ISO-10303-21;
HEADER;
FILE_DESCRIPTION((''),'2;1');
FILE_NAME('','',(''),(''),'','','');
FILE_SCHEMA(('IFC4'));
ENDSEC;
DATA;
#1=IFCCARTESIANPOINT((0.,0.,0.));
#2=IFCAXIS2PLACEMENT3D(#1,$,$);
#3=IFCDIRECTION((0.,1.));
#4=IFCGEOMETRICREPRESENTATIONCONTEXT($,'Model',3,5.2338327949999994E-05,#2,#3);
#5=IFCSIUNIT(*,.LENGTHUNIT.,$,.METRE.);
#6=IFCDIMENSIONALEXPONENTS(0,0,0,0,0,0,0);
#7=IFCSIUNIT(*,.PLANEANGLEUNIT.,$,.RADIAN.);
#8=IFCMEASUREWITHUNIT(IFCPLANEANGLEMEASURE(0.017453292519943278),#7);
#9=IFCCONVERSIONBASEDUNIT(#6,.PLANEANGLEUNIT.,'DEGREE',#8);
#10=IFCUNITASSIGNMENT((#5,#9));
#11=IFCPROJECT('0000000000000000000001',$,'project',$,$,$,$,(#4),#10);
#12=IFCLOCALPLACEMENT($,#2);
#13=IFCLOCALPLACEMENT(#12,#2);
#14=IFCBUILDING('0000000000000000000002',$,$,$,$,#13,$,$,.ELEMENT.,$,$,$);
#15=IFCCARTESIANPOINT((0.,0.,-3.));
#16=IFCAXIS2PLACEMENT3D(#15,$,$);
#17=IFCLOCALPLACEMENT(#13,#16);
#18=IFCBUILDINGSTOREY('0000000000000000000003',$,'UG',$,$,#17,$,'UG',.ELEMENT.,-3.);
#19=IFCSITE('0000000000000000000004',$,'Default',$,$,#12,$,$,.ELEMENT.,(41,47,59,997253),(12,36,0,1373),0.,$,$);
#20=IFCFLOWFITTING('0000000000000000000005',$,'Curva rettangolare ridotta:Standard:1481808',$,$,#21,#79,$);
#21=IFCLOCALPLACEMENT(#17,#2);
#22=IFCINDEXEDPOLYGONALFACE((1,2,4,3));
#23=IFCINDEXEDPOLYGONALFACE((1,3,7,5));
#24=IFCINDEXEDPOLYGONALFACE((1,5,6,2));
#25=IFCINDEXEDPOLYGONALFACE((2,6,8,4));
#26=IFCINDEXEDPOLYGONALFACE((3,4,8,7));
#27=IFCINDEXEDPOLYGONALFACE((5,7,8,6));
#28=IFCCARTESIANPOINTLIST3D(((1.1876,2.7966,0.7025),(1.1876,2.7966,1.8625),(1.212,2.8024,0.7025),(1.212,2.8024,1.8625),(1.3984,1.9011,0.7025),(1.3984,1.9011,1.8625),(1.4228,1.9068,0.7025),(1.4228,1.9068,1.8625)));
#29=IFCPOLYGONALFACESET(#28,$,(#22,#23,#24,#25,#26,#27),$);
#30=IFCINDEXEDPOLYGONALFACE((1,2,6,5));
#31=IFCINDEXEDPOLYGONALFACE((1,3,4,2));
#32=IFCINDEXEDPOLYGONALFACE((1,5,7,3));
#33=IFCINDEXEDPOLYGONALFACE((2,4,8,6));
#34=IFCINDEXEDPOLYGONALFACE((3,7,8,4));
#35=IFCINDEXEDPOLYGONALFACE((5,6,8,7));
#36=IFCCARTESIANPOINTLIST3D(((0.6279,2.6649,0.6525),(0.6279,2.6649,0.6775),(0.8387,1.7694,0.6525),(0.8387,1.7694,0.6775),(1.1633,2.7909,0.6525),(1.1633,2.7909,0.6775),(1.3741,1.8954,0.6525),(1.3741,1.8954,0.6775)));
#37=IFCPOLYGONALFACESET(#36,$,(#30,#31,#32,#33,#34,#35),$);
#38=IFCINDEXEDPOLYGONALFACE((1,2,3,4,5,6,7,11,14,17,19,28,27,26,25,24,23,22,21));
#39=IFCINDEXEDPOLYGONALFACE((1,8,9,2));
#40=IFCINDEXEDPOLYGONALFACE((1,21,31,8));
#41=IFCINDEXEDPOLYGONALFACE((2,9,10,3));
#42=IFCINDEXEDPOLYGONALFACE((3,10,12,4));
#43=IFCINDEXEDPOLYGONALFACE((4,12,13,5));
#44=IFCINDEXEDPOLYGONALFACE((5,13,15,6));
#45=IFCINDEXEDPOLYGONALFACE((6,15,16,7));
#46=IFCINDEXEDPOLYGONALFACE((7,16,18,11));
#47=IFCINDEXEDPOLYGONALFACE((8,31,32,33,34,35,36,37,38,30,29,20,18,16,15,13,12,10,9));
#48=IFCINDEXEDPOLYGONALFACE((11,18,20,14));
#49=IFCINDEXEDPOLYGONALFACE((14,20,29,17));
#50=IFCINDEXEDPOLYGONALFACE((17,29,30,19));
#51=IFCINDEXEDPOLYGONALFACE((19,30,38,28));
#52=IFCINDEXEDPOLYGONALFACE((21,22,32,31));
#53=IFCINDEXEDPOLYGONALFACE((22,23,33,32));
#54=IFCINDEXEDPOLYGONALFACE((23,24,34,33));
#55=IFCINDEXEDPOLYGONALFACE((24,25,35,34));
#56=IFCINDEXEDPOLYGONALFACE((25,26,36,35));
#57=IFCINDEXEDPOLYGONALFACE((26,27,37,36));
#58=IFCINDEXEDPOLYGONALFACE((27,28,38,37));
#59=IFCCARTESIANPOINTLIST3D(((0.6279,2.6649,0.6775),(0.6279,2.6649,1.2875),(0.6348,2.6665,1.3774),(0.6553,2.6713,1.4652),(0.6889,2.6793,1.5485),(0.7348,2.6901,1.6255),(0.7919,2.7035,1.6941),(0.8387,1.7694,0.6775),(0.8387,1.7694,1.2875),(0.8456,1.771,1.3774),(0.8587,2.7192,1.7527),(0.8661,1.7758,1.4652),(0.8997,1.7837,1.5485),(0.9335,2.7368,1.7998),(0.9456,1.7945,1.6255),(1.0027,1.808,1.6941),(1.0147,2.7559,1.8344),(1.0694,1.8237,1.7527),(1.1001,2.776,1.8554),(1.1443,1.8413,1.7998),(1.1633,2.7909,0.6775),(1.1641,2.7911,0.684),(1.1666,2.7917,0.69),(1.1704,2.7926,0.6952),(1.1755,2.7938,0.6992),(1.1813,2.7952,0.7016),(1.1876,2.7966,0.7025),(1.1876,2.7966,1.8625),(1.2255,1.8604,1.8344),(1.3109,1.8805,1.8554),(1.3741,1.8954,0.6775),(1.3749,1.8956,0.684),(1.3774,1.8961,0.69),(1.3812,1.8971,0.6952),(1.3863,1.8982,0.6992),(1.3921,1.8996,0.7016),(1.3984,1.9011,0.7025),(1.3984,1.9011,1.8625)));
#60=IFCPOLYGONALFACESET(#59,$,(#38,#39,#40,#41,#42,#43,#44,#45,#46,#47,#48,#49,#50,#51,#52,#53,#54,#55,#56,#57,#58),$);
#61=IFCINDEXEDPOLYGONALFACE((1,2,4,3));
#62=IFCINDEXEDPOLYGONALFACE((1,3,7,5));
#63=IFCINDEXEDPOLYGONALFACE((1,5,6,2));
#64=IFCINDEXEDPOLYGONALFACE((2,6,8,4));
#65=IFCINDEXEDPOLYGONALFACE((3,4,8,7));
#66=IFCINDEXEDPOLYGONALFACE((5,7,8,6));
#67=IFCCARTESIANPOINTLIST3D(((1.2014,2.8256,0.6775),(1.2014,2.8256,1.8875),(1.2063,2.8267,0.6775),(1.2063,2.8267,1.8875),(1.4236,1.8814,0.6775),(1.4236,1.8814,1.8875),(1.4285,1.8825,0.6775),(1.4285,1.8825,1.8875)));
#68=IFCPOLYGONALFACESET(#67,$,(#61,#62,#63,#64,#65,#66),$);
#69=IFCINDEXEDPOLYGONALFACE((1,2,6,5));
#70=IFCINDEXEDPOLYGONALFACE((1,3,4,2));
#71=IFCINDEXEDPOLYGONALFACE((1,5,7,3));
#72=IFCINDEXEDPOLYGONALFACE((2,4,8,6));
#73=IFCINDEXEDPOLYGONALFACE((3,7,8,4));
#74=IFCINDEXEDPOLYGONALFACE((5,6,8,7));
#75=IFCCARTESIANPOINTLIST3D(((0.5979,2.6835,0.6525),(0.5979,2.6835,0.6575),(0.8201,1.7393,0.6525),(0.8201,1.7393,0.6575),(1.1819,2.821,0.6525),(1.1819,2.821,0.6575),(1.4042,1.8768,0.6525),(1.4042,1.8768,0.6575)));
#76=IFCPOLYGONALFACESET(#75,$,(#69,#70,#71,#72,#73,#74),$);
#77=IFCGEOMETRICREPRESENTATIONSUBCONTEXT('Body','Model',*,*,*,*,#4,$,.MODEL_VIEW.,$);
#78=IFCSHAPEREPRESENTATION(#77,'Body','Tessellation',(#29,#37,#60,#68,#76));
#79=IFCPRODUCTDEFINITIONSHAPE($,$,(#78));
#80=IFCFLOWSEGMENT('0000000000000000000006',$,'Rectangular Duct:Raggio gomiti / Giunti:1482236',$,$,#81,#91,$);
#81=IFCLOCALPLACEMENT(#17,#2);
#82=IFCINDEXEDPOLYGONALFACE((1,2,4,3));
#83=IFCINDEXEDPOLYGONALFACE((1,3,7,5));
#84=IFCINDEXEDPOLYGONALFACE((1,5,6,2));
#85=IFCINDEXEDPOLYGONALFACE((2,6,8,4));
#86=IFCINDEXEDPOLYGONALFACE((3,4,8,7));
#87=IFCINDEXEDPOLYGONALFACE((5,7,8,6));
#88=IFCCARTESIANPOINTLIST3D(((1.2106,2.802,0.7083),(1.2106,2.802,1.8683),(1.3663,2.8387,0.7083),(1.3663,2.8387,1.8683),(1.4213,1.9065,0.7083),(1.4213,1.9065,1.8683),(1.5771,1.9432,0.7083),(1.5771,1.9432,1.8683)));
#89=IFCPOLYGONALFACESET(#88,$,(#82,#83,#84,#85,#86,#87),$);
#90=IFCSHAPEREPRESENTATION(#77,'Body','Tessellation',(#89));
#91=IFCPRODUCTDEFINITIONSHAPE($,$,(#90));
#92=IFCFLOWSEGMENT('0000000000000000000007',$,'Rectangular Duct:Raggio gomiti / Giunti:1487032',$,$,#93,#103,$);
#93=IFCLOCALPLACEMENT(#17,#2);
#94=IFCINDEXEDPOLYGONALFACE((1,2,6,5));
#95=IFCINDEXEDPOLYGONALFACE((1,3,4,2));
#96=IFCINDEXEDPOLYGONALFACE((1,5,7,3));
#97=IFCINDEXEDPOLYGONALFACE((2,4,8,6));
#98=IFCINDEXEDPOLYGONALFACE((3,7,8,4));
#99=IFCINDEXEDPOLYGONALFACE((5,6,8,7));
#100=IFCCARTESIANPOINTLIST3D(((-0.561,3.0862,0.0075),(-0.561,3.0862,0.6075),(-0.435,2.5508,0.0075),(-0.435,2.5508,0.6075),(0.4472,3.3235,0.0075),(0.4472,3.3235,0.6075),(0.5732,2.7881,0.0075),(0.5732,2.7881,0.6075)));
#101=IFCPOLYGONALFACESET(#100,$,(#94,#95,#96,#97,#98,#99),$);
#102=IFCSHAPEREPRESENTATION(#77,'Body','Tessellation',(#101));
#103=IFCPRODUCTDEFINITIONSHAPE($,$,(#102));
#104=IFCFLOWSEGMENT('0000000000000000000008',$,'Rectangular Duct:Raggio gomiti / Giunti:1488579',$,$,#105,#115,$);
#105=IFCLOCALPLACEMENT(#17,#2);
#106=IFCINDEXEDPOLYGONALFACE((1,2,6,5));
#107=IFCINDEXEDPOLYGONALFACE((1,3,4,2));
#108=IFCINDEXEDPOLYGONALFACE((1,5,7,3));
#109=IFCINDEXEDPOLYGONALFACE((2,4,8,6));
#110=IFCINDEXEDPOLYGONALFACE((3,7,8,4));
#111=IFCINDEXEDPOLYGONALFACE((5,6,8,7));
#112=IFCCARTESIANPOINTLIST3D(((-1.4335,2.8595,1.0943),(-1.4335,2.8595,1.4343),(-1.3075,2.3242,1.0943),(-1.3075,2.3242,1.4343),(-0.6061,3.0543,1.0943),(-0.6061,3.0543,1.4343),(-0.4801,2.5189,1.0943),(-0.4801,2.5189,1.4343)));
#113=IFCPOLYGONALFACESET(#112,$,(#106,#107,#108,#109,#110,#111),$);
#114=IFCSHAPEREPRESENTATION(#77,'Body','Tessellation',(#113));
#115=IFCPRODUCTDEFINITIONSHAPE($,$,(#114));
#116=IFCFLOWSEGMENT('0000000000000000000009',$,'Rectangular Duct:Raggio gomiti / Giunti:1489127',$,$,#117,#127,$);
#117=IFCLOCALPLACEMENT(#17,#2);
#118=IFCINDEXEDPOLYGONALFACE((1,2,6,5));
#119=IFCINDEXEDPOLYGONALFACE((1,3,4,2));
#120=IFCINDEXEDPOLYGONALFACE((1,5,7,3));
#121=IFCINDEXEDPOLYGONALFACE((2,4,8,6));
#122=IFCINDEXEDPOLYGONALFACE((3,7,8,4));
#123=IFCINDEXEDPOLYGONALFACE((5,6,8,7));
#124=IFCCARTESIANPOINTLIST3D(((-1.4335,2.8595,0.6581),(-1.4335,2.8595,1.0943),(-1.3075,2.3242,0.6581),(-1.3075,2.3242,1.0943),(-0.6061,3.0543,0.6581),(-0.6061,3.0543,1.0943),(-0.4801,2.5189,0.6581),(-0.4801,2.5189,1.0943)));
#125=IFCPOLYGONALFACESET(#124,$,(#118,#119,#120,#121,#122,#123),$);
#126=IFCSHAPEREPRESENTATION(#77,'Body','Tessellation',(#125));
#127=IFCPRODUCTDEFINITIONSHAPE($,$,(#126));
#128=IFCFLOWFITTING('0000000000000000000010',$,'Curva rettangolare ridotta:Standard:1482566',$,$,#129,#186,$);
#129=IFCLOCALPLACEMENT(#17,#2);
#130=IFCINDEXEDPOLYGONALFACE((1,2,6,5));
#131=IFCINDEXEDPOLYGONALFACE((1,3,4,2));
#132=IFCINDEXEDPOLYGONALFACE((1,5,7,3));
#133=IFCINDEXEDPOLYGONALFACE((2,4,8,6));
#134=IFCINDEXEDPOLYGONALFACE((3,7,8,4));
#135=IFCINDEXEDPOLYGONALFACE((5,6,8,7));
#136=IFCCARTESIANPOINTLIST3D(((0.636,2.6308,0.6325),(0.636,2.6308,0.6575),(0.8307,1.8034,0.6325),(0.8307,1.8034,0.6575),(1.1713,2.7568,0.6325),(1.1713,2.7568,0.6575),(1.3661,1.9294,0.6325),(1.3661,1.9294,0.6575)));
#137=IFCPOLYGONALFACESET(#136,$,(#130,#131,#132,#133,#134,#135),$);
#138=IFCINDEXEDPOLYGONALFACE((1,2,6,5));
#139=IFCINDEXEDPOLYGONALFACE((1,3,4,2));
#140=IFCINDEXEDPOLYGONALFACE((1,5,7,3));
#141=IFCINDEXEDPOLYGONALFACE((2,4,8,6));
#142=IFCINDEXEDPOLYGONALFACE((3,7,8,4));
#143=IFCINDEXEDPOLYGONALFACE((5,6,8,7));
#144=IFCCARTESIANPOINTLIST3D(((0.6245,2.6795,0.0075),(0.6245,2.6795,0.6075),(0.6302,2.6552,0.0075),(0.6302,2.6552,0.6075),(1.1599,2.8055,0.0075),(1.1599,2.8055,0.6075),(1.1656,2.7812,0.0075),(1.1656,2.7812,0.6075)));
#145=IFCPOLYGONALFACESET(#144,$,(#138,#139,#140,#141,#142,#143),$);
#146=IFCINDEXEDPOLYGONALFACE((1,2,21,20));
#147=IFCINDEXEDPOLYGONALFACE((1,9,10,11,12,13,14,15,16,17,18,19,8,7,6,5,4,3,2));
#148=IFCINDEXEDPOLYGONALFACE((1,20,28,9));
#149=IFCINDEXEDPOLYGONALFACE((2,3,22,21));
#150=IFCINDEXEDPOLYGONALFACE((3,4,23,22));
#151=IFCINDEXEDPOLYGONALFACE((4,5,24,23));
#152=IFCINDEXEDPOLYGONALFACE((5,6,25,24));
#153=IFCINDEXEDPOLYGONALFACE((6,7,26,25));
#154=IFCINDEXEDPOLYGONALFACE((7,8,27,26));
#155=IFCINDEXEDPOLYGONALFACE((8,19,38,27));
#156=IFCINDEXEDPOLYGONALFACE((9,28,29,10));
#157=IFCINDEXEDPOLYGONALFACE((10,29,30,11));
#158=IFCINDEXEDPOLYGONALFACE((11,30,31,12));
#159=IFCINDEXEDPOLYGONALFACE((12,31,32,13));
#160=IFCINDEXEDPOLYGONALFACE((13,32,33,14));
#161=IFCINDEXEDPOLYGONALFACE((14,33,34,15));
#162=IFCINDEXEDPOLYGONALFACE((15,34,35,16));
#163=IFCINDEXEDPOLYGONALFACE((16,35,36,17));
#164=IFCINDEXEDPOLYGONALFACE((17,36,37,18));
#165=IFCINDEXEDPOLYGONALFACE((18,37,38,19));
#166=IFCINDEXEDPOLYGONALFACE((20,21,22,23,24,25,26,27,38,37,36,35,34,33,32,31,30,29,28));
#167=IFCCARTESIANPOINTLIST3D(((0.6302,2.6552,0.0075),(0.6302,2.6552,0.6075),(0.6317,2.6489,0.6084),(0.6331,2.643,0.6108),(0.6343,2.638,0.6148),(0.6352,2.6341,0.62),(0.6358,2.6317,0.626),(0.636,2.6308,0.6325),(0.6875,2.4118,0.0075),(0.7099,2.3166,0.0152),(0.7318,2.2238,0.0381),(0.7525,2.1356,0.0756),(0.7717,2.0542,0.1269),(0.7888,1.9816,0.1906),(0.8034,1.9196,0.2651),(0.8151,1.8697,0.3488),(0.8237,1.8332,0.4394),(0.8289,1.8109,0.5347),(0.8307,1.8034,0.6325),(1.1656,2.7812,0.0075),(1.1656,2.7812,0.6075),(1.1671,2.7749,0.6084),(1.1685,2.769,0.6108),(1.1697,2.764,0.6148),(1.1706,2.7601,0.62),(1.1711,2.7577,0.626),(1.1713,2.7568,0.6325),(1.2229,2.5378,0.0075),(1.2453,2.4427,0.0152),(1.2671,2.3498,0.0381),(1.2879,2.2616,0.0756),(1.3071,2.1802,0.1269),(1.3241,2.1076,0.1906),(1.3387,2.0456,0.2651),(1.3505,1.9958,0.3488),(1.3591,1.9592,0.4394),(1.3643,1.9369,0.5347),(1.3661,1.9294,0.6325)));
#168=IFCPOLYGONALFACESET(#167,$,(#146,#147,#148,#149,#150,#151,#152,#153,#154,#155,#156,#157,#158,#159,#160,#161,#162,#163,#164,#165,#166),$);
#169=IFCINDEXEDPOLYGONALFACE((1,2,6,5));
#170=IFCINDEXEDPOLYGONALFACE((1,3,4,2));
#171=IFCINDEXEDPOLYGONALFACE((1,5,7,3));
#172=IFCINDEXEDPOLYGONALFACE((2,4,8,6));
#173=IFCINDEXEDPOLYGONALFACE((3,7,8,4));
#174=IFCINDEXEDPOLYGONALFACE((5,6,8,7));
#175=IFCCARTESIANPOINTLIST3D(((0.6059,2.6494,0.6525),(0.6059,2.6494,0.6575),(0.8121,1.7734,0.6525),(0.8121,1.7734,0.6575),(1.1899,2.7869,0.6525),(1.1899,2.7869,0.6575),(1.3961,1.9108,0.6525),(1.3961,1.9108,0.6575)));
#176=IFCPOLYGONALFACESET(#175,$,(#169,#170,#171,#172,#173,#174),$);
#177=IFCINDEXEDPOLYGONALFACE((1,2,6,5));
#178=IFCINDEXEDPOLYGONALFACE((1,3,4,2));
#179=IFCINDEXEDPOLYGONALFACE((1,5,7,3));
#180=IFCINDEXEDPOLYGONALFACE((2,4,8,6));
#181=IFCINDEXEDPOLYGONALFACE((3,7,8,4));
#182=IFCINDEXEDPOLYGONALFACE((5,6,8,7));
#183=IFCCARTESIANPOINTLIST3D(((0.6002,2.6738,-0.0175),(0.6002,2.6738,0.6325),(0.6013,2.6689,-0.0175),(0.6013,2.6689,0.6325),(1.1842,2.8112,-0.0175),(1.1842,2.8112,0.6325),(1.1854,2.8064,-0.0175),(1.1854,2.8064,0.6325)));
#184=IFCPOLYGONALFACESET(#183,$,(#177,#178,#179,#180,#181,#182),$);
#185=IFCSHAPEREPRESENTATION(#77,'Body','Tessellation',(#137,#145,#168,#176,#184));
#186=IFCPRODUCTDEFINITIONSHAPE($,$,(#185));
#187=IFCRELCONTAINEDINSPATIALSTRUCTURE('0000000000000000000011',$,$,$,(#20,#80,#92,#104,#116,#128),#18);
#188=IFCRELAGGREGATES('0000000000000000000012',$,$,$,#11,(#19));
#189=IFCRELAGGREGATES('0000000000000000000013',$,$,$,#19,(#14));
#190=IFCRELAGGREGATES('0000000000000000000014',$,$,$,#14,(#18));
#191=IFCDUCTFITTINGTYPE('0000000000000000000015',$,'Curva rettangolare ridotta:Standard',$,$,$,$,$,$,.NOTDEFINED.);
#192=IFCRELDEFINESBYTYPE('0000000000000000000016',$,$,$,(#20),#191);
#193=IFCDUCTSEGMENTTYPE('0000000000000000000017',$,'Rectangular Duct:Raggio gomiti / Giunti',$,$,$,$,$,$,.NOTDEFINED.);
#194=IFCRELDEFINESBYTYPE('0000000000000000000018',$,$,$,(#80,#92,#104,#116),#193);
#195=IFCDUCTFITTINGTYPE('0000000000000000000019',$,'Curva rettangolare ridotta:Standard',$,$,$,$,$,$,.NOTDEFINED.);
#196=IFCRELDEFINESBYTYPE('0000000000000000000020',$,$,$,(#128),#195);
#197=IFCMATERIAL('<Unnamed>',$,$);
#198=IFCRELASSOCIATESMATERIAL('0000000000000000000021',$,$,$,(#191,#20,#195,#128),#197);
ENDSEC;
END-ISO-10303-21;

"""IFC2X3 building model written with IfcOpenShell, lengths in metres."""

from ifc_helpers import new_model, entity, si_unit, converted_unit, direction, frame, frame_2d, origin, origin_2d_with_axis, place, context, subcontext, project, spatial, polyline, circle_curve, parameter, trimmed, segment, composite_curve, rectangle, outline, extrude, source, transform, mapped, material, type_object, type_shapes, element, save


model = new_model("IFC2X3")

# Units and contexts
model_context = context("Model", 3, precision=5.2338327949999994e-05, world=origin(), true_north=direction((0.0, 1.0)))
body_context = subcontext(model_context, "Body", "Model", "MODEL_VIEW")
ifc_project = project(units=[si_unit("LENGTHUNIT", "METRE"), converted_unit("PLANEANGLEUNIT", "DEGREE", entity("IfcPlaneAngleMeasure", 0.017453292519943278), si_unit("PLANEANGLEUNIT", "RADIAN"), dimensions=[0, 0, 0, 0, 0, 0, 0])], contexts=[model_context])

# Site, building, storey
site_placement = place(None, origin())
site = spatial("IfcSite", under=ifc_project, at=site_placement, Name="Default", CompositionType="ELEMENT", RefLatitude=(41, 47, 59, 997253), RefLongitude=(12, 36, 0, 1373), RefElevation=0.0)
building_placement = place(site_placement, origin())
building = spatial("IfcBuilding", under=site, at=building_placement, CompositionType="ELEMENT")
storey_placement = place(building_placement, frame((0.0, 0.0, -3.0)))
storey = spatial("IfcBuildingStorey", under=building, at=storey_placement, Name="UG", LongName="UG", CompositionType="ELEMENT", Elevation=-3.0)

# Flow fitting
ifc_material = material(Name="<Unnamed>")
duct_fitting_type_1 = type_object("IfcDuctFittingType", Name="Curva rettangolare ridotta:Standard", PredefinedType="NOTDEFINED", material=ifc_material)
shared_shape_1 = source(origin(), body_context, "Body", "SweptSolid", [
    extrude(rectangle(XDim=0.025, YDim=1.16, at=frame_2d((0.0, 0.0), x_axis=(1.0, 0.0))), frame((-0.3125, 0.0, -0.46), z_axis=(0.0, 0.0, 1.0), x_axis=(-1.0, 0.0, 0.0)), (0.0, 0.0, 1.0), 0.92),
    extrude(rectangle(XDim=0.025, YDim=0.55, at=frame_2d((0.0, 0.0), x_axis=(1.0, 0.0))), frame((0.0, 0.6175, -0.46), z_axis=(0.0, 0.0, 1.0), x_axis=(0.0, 1.0, 0.0)), (0.0, 0.0, 1.0), 0.92),
    extrude(outline(composite_curve([segment(polyline([(-0.21, -0.364), (0.34, -0.364)]), True, "CONTINUOUS"), segment(polyline([(0.34, -0.364), (0.34, 0.246)]), True, "CONTINUOUS"), segment(trimmed(circle_curve(frame_2d((-0.235, 0.246), x_axis=(1.0, 0.0)), 0.575), [parameter(0.0)], [parameter(90.0)], True, "PARAMETER"), True, "CONTINUOUS"), segment(polyline([(-0.235, 0.821), (-0.235, -0.339)]), True, "CONTINUOUS"), segment(trimmed(circle_curve(frame_2d((-0.235, -0.364), x_axis=(1.0, 0.0)), 0.025), [parameter(0.0)], [parameter(90.0)], True, "PARAMETER"), False, "CONTINUOUS")], self_intersect=False)), frame((-0.065, 0.241, -0.46), z_axis=(0.0, 0.0, -1.0), x_axis=(1.0, 0.0, 0.0)), (0.0, 0.0, -1.0), 0.92),
    extrude(rectangle(XDim=0.005, YDim=1.21, at=origin_2d_with_axis()), frame((-0.3225, 0.0, -0.485)), (0.0, 0.0, 1.0), 0.97),
    extrude(rectangle(XDim=0.005, YDim=0.6, at=origin_2d_with_axis()), frame((0.0, 0.6275, -0.485), z_axis=(0.0, 0.0, 1.0), x_axis=(0.0, 1.0, 0.0)), (0.0, 0.0, 1.0), 0.97),
])
type_shapes(duct_fitting_type_1, [shared_shape_1])
flow_fitting_1_placement = place(storey_placement, frame((1.001, 2.2801, 1.2825), z_axis=(0.229116, -0.973399, 0.0), x_axis=(-0.973399, -0.229116, 0.0)))
element("IfcFlowFitting", 1, at=flow_fitting_1_placement, inside=storey, type_object=duct_fitting_type_1, material=ifc_material, Name="Curva rettangolare ridotta:Standard:1481808", context=body_context, shape_type="MappedRepresentation", body=[
    mapped(shared_shape_1, transform((0.0, 0.0, 0.0), scale=1.0)),
])

# Flow segments
duct_segment_type = type_object("IfcDuctSegmentType", Name="Rectangular Duct:Raggio gomiti / Giunti", PredefinedType="NOTDEFINED")
flow_segment_1_placement = place(storey_placement, origin())
element("IfcFlowSegment", 2, at=flow_segment_1_placement, inside=storey, type_object=duct_segment_type, Name="Rectangular Duct:Raggio gomiti / Giunti:1482236", context=body_context, shape_type="SweptSolid", body=[
    extrude(rectangle(XDim=0.16, YDim=0.92, at=frame_2d((0.0, 0.0), x_axis=(1.0, 0.0))), frame((1.3938, 2.3726, 0.7083), z_axis=(0.0, 0.0, 1.0), x_axis=(0.973399, 0.229116, 0.0)), (0.0, 0.0, 1.0), 1.16),
])
flow_segment_2_placement = place(storey_placement, origin())
element("IfcFlowSegment", 3, at=flow_segment_2_placement, inside=storey, type_object=duct_segment_type, Name="Rectangular Duct:Raggio gomiti / Giunti:1487032", context=body_context, shape_type="SweptSolid", body=[
    extrude(rectangle(XDim=1.0358, YDim=0.55, at=frame_2d((0.0, 0.0), x_axis=(1.0, 0.0))), frame((0.0061, 2.9372, 0.0075), z_axis=(0.0, 0.0, 1.0), x_axis=(-0.973399, -0.229116, 0.0)), (0.0, 0.0, 1.0), 0.6),
])
flow_segment_3_placement = place(storey_placement, origin())
element("IfcFlowSegment", 4, at=flow_segment_3_placement, inside=storey, type_object=duct_segment_type, Name="Rectangular Duct:Raggio gomiti / Giunti:1488579", context=body_context, shape_type="SweptSolid", body=[
    extrude(rectangle(XDim=0.85, YDim=0.55, at=origin_2d_with_axis()), frame((-0.9568, 2.6892, 1.0943), z_axis=(0.0, 0.0, 1.0), x_axis=(-0.973399, -0.229116, 0.0)), (0.0, 0.0, 1.0), 0.34),
])
flow_segment_4_placement = place(storey_placement, origin())
element("IfcFlowSegment", 5, at=flow_segment_4_placement, inside=storey, type_object=duct_segment_type, Name="Rectangular Duct:Raggio gomiti / Giunti:1489127", context=body_context, shape_type="SweptSolid", body=[
    extrude(rectangle(XDim=0.55, YDim=0.85, at=frame_2d((0.0, 0.0), x_axis=(1.0, 0.0))), frame((-0.9568, 2.6892, 0.6581), z_axis=(0.0, 0.0, 1.0), x_axis=(0.229116, -0.973399, 0.0)), (0.0, 0.0, 1.0), 0.4362),
])

# Flow fitting
duct_fitting_type_2 = type_object("IfcDuctFittingType", Name="Curva rettangolare ridotta:Standard", PredefinedType="NOTDEFINED", material=ifc_material)
shared_shape_2 = source(origin(), body_context, "Body", "SweptSolid", [
    extrude(rectangle(XDim=0.025, YDim=0.85, at=origin_2d_with_axis()), frame((-0.3375, 0.0, -0.275), z_axis=(0.0, 0.0, 1.0), x_axis=(-1.0, 0.0, 0.0)), (0.0, 0.0, 1.0), 0.55),
    extrude(rectangle(XDim=0.025, YDim=0.6, at=origin_2d_with_axis()), frame((0.0, 0.4625, -0.275), z_axis=(0.0, 0.0, 1.0), x_axis=(0.0, 1.0, 0.0)), (0.0, 0.0, 1.0), 0.55),
    extrude(outline(composite_curve([segment(polyline([(-0.23, -0.23), (0.37, -0.23)]), True, "CONTINUOUS"), segment(polyline([(0.37, -0.23), (0.37, 0.02)]), True, "CONTINUOUS"), segment(trimmed(circle_curve(frame_2d((-0.255, 0.02), x_axis=(1.0, 0.0)), 0.625), [parameter(0.0)], [parameter(90.0)], True, "PARAMETER"), True, "CONTINUOUS"), segment(polyline([(-0.255, 0.645), (-0.255, -0.205)]), True, "CONTINUOUS"), segment(trimmed(circle_curve(frame_2d((-0.255, -0.23), x_axis=(1.0, 0.0)), 0.025), [parameter(0.0)], [parameter(90.0)], True, "PARAMETER"), False, "CONTINUOUS")], self_intersect=False)), frame((-0.07, 0.22, -0.275), z_axis=(0.0, 0.0, -1.0), x_axis=(1.0, 0.0, 0.0)), (0.0, 0.0, -1.0), 0.55),
    extrude(rectangle(XDim=0.005, YDim=0.9, at=origin_2d_with_axis()), frame((-0.3475, 0.0, -0.3)), (0.0, 0.0, 1.0), 0.6),
    extrude(rectangle(XDim=0.005, YDim=0.65, at=origin_2d_with_axis()), frame((0.0, 0.4725, -0.3), z_axis=(0.0, 0.0, 1.0), x_axis=(0.0, 1.0, 0.0)), (0.0, 0.0, 1.0), 0.6),
])
type_shapes(duct_fitting_type_2, [shared_shape_2])
flow_fitting_2_placement = place(storey_placement, frame((1.001, 2.2801, 0.3075), z_axis=(0.973399, 0.229116, 0.0), x_axis=(0.0, 0.0, -1.0)))
element("IfcFlowFitting", 6, at=flow_fitting_2_placement, inside=storey, type_object=duct_fitting_type_2, material=ifc_material, Name="Curva rettangolare ridotta:Standard:1482566", context=body_context, shape_type="MappedRepresentation", body=[
    mapped(shared_shape_2, transform((0.0, 0.0, 0.0), scale=1.0)),
])

save(model, "model.ifc")
